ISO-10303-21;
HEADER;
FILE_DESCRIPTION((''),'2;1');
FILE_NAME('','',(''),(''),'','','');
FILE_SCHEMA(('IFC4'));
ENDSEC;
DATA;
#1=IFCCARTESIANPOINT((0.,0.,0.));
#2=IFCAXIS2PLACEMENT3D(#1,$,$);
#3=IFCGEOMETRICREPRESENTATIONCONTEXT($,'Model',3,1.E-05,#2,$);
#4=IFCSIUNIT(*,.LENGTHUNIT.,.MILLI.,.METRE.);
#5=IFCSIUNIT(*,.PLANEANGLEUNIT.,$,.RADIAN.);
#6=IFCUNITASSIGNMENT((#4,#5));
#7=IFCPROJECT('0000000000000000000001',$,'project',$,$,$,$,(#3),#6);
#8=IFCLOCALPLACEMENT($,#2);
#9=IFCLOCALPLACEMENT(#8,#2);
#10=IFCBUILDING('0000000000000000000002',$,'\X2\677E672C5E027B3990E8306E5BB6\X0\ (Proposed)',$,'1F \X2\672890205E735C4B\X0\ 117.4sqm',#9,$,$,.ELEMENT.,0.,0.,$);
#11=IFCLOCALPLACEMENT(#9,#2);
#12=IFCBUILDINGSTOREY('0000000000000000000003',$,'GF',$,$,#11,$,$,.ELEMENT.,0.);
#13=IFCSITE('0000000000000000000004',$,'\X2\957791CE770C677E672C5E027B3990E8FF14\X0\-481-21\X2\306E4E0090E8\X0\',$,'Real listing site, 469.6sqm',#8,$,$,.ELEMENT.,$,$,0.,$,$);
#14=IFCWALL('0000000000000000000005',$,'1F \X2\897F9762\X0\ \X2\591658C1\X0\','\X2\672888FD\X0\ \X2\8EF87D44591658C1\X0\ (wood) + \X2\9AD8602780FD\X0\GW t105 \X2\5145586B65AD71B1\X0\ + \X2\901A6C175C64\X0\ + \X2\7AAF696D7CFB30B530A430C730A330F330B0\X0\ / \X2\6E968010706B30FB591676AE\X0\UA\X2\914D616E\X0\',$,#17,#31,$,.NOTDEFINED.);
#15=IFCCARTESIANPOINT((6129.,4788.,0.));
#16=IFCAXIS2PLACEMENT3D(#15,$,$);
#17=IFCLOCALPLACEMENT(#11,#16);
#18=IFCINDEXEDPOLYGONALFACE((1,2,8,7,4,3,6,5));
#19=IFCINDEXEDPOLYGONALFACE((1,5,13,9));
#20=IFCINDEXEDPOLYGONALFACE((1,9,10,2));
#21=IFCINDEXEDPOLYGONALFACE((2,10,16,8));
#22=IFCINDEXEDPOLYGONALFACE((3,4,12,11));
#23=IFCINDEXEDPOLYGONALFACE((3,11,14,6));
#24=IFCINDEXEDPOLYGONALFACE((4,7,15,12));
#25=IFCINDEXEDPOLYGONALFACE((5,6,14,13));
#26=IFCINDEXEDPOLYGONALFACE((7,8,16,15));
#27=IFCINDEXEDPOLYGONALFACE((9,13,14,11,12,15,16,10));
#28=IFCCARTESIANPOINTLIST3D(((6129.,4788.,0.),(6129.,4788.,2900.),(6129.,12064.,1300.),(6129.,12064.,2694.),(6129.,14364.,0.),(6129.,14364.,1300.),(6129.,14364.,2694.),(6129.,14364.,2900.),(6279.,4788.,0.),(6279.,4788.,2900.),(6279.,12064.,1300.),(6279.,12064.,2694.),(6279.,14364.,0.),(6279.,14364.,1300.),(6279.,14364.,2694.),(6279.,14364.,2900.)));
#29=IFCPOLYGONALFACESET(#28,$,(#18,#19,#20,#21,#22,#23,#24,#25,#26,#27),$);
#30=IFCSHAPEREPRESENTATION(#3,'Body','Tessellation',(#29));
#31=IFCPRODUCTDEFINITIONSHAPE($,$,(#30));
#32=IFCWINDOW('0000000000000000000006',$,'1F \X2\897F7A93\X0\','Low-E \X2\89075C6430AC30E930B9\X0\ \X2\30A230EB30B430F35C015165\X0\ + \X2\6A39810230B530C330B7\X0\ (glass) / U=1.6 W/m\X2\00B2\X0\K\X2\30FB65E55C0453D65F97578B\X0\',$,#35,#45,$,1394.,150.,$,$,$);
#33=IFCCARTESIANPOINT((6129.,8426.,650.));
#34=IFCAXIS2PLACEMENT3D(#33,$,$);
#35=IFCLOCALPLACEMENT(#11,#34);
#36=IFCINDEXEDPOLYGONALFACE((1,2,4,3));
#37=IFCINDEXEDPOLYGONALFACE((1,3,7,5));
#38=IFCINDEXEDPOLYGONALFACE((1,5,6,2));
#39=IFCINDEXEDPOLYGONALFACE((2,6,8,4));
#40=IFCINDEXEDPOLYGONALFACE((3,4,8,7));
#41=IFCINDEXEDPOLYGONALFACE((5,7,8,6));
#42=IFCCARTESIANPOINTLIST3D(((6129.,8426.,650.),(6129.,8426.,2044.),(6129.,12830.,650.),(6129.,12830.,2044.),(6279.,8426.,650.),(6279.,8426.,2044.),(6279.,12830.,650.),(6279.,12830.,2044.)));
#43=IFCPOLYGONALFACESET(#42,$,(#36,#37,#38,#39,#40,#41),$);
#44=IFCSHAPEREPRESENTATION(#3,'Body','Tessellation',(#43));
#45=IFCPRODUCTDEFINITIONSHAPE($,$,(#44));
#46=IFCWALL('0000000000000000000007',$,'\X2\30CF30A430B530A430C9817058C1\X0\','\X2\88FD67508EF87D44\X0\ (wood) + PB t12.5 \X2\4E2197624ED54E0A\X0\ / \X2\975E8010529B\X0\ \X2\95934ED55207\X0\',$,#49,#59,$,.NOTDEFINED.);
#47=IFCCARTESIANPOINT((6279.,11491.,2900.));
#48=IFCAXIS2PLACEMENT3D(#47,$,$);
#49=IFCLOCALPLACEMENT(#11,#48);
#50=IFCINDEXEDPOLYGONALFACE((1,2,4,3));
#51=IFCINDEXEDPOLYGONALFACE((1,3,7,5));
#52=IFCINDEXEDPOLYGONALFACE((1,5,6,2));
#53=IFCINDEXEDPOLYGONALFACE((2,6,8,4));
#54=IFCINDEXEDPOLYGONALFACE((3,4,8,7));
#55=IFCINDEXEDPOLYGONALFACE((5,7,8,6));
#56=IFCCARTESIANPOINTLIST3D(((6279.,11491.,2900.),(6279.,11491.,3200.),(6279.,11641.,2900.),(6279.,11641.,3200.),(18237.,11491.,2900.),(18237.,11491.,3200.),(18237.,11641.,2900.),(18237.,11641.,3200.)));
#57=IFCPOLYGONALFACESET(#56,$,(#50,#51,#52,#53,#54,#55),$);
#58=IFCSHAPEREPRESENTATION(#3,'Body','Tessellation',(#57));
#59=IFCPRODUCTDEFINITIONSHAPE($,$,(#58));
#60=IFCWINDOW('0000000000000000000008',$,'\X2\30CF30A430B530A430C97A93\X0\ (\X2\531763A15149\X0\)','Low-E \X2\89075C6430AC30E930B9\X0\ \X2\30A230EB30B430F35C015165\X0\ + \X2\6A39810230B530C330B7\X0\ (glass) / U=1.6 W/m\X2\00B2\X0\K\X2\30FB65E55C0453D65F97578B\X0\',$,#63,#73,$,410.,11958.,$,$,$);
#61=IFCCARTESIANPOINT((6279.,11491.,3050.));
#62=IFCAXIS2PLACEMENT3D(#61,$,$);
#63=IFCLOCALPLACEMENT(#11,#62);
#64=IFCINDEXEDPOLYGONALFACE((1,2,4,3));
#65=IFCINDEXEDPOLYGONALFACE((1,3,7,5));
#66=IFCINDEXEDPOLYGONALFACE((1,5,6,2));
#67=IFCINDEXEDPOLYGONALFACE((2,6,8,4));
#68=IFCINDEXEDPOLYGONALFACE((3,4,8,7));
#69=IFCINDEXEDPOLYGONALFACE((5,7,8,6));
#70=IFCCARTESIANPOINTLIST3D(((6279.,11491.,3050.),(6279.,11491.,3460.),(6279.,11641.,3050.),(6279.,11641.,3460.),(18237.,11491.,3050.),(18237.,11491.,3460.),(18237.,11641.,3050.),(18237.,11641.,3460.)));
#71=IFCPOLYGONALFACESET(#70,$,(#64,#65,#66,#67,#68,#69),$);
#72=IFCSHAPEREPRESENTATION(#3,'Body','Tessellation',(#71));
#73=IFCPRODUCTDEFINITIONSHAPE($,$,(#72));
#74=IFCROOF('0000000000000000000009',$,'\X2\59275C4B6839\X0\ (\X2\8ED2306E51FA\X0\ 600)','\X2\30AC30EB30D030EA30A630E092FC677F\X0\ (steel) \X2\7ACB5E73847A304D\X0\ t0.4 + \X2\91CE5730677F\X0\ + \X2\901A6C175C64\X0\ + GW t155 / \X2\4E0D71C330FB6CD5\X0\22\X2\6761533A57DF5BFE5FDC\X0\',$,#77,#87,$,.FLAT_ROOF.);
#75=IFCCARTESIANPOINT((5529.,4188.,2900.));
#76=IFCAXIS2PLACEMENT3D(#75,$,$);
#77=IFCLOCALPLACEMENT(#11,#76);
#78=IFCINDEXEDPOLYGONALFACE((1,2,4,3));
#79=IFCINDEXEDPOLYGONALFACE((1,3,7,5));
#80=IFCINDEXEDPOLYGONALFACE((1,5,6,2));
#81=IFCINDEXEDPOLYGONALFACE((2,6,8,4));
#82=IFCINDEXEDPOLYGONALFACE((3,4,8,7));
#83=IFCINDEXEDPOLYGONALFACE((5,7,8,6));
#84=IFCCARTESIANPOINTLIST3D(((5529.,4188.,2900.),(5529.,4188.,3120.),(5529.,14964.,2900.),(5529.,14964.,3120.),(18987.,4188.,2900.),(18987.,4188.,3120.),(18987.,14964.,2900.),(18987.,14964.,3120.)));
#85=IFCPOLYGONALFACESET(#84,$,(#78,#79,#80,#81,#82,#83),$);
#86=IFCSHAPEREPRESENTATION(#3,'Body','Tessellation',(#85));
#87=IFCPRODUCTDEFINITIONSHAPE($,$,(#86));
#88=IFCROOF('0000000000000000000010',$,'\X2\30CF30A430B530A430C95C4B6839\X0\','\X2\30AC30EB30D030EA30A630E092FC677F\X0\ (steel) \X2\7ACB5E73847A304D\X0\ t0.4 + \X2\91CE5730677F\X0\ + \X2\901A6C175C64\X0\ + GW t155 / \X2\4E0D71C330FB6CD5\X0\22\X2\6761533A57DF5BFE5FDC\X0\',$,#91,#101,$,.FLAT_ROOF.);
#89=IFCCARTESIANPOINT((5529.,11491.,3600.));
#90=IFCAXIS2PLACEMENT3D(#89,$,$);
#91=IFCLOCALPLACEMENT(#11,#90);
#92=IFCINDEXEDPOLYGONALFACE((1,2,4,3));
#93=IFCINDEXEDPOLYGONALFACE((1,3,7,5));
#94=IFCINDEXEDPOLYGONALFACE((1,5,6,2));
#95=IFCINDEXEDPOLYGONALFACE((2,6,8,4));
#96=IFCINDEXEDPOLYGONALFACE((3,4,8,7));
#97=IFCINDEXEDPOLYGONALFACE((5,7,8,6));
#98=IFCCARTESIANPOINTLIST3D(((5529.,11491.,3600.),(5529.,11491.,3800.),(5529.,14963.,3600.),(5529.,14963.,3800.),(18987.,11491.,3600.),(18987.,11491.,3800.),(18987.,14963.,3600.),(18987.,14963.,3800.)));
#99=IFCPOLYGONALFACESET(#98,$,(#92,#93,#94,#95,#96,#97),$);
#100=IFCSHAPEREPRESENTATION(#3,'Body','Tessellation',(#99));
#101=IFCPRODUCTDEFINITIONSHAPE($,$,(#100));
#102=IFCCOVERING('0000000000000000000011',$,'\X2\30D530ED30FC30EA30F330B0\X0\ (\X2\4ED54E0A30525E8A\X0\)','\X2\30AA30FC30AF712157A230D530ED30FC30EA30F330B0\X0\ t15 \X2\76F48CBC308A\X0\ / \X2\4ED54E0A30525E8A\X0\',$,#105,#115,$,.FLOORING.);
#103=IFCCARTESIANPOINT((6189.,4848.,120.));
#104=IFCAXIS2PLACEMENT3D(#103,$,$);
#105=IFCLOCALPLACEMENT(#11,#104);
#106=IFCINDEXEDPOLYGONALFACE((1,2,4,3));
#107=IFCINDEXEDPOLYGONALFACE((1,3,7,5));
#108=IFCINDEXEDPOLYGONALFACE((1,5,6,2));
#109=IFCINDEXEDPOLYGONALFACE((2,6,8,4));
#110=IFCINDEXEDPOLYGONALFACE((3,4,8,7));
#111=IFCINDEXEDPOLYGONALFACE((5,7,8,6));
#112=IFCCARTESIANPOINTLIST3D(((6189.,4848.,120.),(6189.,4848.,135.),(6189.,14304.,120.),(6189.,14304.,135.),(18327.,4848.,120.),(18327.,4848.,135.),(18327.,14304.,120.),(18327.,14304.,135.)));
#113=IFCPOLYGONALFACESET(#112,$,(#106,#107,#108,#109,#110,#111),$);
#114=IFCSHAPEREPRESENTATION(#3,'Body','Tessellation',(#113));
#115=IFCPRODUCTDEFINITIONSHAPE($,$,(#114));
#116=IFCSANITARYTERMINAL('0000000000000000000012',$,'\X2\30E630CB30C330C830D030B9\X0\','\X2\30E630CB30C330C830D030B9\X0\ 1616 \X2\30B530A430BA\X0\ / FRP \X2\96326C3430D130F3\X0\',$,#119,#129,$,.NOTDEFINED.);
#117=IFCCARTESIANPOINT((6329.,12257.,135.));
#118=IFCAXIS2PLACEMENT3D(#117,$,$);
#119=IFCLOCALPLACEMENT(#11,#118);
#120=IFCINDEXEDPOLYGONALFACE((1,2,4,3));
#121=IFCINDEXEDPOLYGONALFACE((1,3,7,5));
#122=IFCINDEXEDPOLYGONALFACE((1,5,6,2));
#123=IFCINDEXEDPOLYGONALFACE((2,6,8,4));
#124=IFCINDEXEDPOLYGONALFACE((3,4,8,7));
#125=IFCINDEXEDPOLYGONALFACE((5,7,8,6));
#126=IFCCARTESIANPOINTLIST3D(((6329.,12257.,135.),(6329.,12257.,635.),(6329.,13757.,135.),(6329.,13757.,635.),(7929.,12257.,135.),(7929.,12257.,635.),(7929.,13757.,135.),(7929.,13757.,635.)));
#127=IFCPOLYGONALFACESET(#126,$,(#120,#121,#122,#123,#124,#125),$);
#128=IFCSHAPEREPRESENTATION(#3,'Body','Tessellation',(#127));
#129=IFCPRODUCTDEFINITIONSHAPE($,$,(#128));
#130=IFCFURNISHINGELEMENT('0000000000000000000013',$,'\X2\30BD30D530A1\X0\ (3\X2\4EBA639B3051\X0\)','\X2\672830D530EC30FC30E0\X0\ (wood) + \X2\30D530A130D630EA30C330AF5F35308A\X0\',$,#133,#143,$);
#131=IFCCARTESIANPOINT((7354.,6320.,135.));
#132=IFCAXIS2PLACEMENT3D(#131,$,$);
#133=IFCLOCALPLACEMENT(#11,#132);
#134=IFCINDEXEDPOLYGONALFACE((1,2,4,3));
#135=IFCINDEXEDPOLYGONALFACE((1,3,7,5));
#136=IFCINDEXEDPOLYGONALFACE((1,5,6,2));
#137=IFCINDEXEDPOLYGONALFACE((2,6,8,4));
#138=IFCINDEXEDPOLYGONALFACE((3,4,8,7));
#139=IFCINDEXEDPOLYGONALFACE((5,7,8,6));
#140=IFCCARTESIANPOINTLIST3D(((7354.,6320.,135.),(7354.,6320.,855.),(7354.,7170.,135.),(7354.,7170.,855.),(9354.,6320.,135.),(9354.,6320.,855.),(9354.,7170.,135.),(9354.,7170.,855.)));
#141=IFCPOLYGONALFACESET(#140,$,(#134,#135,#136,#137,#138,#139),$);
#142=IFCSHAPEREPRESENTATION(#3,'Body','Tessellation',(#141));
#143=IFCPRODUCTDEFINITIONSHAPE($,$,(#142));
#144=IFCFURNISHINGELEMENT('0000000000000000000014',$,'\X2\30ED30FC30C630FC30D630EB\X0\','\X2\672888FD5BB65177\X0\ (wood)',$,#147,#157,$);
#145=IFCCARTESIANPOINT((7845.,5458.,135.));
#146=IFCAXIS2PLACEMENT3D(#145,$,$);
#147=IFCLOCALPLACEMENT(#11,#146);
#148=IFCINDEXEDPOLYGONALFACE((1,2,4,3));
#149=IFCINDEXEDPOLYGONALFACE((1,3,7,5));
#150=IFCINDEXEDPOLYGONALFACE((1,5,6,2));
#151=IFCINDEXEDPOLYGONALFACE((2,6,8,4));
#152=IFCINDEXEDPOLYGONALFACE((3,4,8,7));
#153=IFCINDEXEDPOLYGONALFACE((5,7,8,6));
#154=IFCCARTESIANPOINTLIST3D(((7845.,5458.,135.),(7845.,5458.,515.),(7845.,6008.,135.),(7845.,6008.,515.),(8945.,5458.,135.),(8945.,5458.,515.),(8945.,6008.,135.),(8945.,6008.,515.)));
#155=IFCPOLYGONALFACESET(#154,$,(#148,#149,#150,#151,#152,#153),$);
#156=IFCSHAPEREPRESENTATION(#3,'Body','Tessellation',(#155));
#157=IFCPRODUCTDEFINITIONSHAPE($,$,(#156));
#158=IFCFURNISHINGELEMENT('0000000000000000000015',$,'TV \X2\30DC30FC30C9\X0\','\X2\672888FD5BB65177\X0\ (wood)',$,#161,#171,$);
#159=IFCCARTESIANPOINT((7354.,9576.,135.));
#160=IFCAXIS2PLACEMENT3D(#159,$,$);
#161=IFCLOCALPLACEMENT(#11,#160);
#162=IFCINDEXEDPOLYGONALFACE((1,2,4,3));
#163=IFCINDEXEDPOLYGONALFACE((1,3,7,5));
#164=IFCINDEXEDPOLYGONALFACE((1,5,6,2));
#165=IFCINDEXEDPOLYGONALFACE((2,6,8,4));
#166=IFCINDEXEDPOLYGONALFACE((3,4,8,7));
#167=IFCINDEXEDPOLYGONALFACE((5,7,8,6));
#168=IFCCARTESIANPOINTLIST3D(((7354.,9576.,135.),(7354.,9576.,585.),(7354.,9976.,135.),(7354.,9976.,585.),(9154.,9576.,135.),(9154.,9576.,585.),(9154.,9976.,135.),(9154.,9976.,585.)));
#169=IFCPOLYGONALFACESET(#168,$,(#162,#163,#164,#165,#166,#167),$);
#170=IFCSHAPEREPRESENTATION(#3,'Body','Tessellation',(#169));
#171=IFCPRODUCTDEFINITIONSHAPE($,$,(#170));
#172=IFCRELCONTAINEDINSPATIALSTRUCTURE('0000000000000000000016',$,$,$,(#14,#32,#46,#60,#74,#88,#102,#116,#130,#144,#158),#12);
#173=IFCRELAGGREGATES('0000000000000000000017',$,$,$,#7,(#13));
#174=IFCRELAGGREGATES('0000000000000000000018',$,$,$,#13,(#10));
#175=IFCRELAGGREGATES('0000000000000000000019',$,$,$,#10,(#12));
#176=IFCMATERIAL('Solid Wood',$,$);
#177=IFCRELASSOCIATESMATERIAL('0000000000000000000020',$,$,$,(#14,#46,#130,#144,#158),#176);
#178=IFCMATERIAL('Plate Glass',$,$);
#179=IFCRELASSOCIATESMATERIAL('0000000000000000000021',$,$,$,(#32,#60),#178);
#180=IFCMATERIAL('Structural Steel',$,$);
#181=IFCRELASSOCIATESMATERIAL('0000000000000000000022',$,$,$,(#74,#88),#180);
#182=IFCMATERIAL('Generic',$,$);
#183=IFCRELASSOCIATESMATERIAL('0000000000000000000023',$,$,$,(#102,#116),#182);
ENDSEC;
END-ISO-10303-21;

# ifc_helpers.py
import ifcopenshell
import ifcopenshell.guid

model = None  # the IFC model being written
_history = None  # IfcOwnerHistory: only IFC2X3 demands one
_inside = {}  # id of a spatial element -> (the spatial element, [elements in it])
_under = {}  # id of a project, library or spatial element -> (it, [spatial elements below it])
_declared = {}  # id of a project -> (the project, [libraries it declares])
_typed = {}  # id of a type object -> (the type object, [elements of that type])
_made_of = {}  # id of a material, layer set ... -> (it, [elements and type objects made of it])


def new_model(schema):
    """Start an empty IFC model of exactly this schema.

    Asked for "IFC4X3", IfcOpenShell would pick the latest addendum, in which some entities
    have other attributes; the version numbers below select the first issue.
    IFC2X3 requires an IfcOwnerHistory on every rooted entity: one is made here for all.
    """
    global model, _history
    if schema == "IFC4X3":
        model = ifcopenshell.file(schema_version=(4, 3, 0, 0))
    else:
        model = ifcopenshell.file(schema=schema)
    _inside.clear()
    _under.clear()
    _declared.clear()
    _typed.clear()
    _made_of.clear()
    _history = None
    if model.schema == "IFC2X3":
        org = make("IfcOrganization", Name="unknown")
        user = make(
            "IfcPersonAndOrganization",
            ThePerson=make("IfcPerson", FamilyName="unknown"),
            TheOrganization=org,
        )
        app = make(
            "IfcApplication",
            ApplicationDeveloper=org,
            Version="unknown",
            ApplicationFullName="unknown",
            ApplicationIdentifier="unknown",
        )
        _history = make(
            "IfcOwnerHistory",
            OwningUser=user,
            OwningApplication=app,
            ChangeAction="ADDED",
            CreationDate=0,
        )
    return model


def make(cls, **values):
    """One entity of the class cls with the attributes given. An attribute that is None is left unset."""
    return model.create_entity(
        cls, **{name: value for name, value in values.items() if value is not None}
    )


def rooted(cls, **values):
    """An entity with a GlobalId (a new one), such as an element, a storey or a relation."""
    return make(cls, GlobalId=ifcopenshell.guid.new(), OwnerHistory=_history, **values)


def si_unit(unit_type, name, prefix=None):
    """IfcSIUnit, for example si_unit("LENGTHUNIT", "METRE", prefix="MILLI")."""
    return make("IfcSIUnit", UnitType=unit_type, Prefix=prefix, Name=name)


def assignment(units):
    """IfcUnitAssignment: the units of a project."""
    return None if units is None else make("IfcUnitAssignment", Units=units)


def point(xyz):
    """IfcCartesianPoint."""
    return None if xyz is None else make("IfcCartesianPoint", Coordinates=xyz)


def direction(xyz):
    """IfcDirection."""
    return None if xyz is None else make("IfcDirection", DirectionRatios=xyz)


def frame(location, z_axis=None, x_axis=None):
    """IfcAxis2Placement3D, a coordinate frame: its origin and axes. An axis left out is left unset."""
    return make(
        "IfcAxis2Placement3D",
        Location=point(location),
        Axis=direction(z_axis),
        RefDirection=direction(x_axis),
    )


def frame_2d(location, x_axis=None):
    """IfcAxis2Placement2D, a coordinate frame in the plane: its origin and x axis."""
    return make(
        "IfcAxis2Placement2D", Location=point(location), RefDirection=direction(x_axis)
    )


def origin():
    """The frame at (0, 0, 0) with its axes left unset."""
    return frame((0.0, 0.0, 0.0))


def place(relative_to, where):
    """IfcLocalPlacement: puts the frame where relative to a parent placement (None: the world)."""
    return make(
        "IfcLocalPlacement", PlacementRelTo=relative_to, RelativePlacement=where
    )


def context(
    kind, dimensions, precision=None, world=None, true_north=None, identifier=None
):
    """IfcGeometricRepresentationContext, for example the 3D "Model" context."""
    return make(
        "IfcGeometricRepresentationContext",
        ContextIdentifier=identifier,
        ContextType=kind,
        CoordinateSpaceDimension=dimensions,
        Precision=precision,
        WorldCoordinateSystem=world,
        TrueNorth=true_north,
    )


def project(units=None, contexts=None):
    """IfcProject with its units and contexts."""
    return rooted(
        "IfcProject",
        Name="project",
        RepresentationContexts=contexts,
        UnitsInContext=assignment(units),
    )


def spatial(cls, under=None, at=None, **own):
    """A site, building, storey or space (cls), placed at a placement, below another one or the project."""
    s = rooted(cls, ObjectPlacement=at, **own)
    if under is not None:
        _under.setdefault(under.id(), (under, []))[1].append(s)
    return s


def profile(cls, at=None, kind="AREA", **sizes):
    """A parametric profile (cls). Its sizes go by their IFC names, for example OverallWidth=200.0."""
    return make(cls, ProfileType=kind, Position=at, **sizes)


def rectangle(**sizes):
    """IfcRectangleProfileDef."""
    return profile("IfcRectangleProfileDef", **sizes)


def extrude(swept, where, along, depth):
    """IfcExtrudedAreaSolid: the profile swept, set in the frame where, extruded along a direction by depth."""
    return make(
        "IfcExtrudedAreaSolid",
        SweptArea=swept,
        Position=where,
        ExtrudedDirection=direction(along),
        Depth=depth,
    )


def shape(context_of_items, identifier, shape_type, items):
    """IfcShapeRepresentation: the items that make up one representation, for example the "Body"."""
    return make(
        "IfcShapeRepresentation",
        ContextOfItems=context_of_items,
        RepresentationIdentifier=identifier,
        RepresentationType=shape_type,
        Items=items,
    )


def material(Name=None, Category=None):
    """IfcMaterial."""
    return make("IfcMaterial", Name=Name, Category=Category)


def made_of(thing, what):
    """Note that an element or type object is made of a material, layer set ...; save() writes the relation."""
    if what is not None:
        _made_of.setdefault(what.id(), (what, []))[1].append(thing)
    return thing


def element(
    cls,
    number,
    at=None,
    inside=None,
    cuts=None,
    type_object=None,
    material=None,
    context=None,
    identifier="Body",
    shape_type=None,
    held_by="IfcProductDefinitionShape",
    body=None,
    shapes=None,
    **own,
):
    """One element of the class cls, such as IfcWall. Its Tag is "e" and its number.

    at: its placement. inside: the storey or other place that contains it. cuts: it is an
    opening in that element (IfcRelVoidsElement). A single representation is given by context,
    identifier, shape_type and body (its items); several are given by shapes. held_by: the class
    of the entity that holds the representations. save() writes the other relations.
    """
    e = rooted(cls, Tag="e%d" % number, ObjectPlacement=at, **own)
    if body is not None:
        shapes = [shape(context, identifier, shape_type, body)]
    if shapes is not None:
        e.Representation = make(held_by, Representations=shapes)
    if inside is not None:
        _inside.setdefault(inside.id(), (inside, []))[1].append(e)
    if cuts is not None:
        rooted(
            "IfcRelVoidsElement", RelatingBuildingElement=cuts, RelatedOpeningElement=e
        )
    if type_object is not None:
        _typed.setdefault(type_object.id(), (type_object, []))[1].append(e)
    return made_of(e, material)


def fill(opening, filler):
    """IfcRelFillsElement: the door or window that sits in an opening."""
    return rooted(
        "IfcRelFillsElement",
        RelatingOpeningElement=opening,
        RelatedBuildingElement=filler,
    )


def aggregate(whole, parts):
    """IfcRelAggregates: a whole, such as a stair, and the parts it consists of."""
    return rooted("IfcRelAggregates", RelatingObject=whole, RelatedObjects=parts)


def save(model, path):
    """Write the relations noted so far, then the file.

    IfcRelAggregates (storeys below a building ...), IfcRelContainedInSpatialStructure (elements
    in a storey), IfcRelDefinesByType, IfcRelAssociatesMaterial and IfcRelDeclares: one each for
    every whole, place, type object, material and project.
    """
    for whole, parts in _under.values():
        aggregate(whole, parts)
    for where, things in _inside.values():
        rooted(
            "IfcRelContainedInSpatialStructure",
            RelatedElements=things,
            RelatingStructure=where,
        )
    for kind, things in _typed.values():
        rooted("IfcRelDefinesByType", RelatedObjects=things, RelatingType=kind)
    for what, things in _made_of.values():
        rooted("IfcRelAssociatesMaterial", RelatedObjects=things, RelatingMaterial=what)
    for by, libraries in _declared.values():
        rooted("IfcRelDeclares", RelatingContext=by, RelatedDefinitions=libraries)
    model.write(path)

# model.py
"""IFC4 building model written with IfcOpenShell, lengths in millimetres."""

from ifc_helpers import new_model, si_unit, frame, frame_2d, origin, place, context, project, spatial, rectangle, extrude, material, element, fill, save


model = new_model("IFC4")

# Units and contexts
model_context = context("Model", 3, precision=1e-05, world=origin())
ifc_project = project(units=[si_unit("LENGTHUNIT", "METRE", prefix="MILLI"), si_unit("PLANEANGLEUNIT", "RADIAN")], contexts=[model_context])

# Site, building, storey
site_placement = place(None, origin())
site = spatial("IfcSite", under=ifc_project, at=site_placement, Name="長野県松本市笹部４-481-21の一部", ObjectType="Real listing site, 469.6sqm", CompositionType="ELEMENT", RefElevation=0.0)
building_placement = place(site_placement, origin())
building = spatial("IfcBuilding", under=site, at=building_placement, Name="松本市笹部の家 (Proposed)", ObjectType="1F 木造平屋 117.4sqm", CompositionType="ELEMENT", ElevationOfRefHeight=0.0, ElevationOfTerrain=0.0)
storey_placement = place(building_placement, origin())
storey = spatial("IfcBuildingStorey", under=building, at=storey_placement, Name="GF", CompositionType="ELEMENT", Elevation=0.0)

# Shared definitions
ifc_material_1 = material(Name="Solid Wood")

# Shared definitions
ifc_material_2 = material(Name="Plate Glass")

# Wall, opening, window
wall_1_placement = place(storey_placement, frame((6129.0, 4788.0, 0.0)))
wall_1 = element("IfcWall", 1, at=wall_1_placement, inside=storey, material=ifc_material_1, Name="1F 西面 外壁", Description="木製 軸組外壁 (wood) + 高性能GW t105 充填断熱 + 通気層 + 窯業系サイディング / 準耐火・外皮UA配慮", PredefinedType="NOTDEFINED", context=model_context, shape_type="SweptSolid", body=[
    extrude(rectangle(XDim=150.0, YDim=9576.0, at=frame_2d((75.0, 4788.0))), frame((6129.0, 4788.0, 0.0)), (0.0, 0.0, 1.0), 2900.0),
])
opening_1_placement = place(storey_placement, frame((6129.0, 8426.0, 650.0)))
opening_1 = element("IfcOpeningElement", 2, at=opening_1_placement, cuts=wall_1, PredefinedType="NOTDEFINED", context=model_context, shape_type="SweptSolid", body=[
    extrude(rectangle(XDim=150.0, YDim=4404.0, at=frame_2d((75.0, 2202.0))), frame((6129.0, 8426.0, 650.0)), (0.0, 0.0, 1.0), 1394.0),
])
window_1_placement = place(storey_placement, frame((6129.0, 8426.0, 650.0)))
window_1 = element("IfcWindow", 3, at=window_1_placement, inside=storey, material=ifc_material_2, Name="1F 西窓", Description="Low-E 複層ガラス アルゴン封入 + 樹脂サッシ (glass) / U=1.6 W/m²K・日射取得型", OverallHeight=1394.0, OverallWidth=150.0, context=model_context, shape_type="SweptSolid", body=[
    extrude(rectangle(XDim=150.0, YDim=4404.0, at=frame_2d((75.0, 2202.0))), frame((6129.0, 8426.0, 650.0)), (0.0, 0.0, 1.0), 1394.0),
])
fill(opening_1, window_1)

# Wall, opening, window
wall_2_placement = place(storey_placement, frame((6279.0, 11491.0, 2900.0)))
wall_2 = element("IfcWall", 4, at=wall_2_placement, inside=storey, material=ifc_material_1, Name="ハイサイド腰壁", Description="製材軸組 (wood) + PB t12.5 両面仕上 / 非耐力 間仕切", PredefinedType="NOTDEFINED", context=model_context, shape_type="SweptSolid", body=[
    extrude(rectangle(XDim=11958.0, YDim=150.0, at=frame_2d((5979.0, 75.0))), frame((6279.0, 11491.0, 2900.0)), (0.0, 0.0, 1.0), 700.0),
])
opening_2_placement = place(storey_placement, frame((6279.0, 11491.0, 3050.0)))
opening_2 = element("IfcOpeningElement", 5, at=opening_2_placement, cuts=wall_2, PredefinedType="NOTDEFINED", context=model_context, shape_type="SweptSolid", body=[
    extrude(rectangle(XDim=11958.0, YDim=150.0, at=frame_2d((5979.0, 75.0))), frame((6279.0, 11491.0, 3050.0)), (0.0, 0.0, 1.0), 410.0),
])
window_2_placement = place(storey_placement, frame((6279.0, 11491.0, 3050.0)))
window_2 = element("IfcWindow", 6, at=window_2_placement, inside=storey, material=ifc_material_2, Name="ハイサイド窓 (北採光)", Description="Low-E 複層ガラス アルゴン封入 + 樹脂サッシ (glass) / U=1.6 W/m²K・日射取得型", OverallHeight=410.0, OverallWidth=11958.0, context=model_context, shape_type="SweptSolid", body=[
    extrude(rectangle(XDim=11958.0, YDim=150.0, at=frame_2d((5979.0, 75.0))), frame((6279.0, 11491.0, 3050.0)), (0.0, 0.0, 1.0), 410.0),
])
fill(opening_2, window_2)

# Roofs
ifc_material_3 = material(Name="Structural Steel")
roof_1_placement = place(storey_placement, frame((5529.0, 4188.0, 2900.0)))
element("IfcRoof", 7, at=roof_1_placement, inside=storey, material=ifc_material_3, Name="大屋根 (軒の出 600)", Description="ガルバリウム鋼板 (steel) 立平葺き t0.4 + 野地板 + 通気層 + GW t155 / 不燃・法22条区域対応", PredefinedType="FLAT_ROOF", context=model_context, shape_type="SweptSolid", body=[
    extrude(rectangle(XDim=13458.0, YDim=10776.0, at=frame_2d((6729.0, 5388.0))), frame((5529.0, 4188.0, 2900.0)), (0.0, 0.0, 1.0), 220.0),
])
roof_2_placement = place(storey_placement, frame((5529.0, 11491.0, 3600.0)))
element("IfcRoof", 8, at=roof_2_placement, inside=storey, material=ifc_material_3, Name="ハイサイド屋根", Description="ガルバリウム鋼板 (steel) 立平葺き t0.4 + 野地板 + 通気層 + GW t155 / 不燃・法22条区域対応", PredefinedType="FLAT_ROOF", context=model_context, shape_type="SweptSolid", body=[
    extrude(rectangle(XDim=13458.0, YDim=3472.0, at=frame_2d((6729.0, 1736.0))), frame((5529.0, 11491.0, 3600.0)), (0.0, 0.0, 1.0), 200.0),
])

# Covering
ifc_material_4 = material(Name="Generic")
covering_placement = place(storey_placement, frame((6189.0, 4848.0, 120.0)))
element("IfcCovering", 9, at=covering_placement, inside=storey, material=ifc_material_4, Name="フローリング (仕上げ床)", Description="オーク無垢フローリング t15 直貼り / 仕上げ床", PredefinedType="FLOORING", context=model_context, shape_type="SweptSolid", body=[
    extrude(rectangle(XDim=12138.0, YDim=9456.0, at=frame_2d((6069.0, 4728.0))), frame((6189.0, 4848.0, 120.0)), (0.0, 0.0, 1.0), 15.0),
])

# Sanitary terminal
sanitary_terminal_placement = place(storey_placement, frame((6329.0, 12257.0, 135.0)))
element("IfcSanitaryTerminal", 10, at=sanitary_terminal_placement, inside=storey, material=ifc_material_4, Name="ユニットバス", Description="ユニットバス 1616 サイズ / FRP 防水パン", PredefinedType="NOTDEFINED", context=model_context, shape_type="SweptSolid", body=[
    extrude(rectangle(XDim=1600.0, YDim=1500.0, at=frame_2d((800.0, 750.0))), frame((6329.0, 12257.0, 135.0)), (0.0, 0.0, 1.0), 500.0),
])

# Furnishing elements
furnishing_1_placement = place(storey_placement, frame((7354.0, 6320.0, 135.0)))
element("IfcFurnishingElement", 11, at=furnishing_1_placement, inside=storey, material=ifc_material_1, Name="ソファ (3人掛け)", Description="木フレーム (wood) + ファブリック張り", context=model_context, shape_type="SweptSolid", body=[
    extrude(rectangle(XDim=2000.0, YDim=850.0, at=frame_2d((1000.0, 425.0))), frame((7354.0, 6320.0, 135.0)), (0.0, 0.0, 1.0), 720.0),
])
furnishing_2_placement = place(storey_placement, frame((7845.0, 5458.0, 135.0)))
element("IfcFurnishingElement", 12, at=furnishing_2_placement, inside=storey, material=ifc_material_1, Name="ローテーブル", Description="木製家具 (wood)", context=model_context, shape_type="SweptSolid", body=[
    extrude(rectangle(XDim=1100.0, YDim=550.0, at=frame_2d((550.0, 275.0))), frame((7845.0, 5458.0, 135.0)), (0.0, 0.0, 1.0), 380.0),
])
furnishing_3_placement = place(storey_placement, frame((7354.0, 9576.0, 135.0)))
element("IfcFurnishingElement", 13, at=furnishing_3_placement, inside=storey, material=ifc_material_1, Name="TV ボード", Description="木製家具 (wood)", context=model_context, shape_type="SweptSolid", body=[
    extrude(rectangle(XDim=1800.0, YDim=400.0, at=frame_2d((900.0, 200.0))), frame((7354.0, 9576.0, 135.0)), (0.0, 0.0, 1.0), 450.0),
])

save(model, "model.ifc")
